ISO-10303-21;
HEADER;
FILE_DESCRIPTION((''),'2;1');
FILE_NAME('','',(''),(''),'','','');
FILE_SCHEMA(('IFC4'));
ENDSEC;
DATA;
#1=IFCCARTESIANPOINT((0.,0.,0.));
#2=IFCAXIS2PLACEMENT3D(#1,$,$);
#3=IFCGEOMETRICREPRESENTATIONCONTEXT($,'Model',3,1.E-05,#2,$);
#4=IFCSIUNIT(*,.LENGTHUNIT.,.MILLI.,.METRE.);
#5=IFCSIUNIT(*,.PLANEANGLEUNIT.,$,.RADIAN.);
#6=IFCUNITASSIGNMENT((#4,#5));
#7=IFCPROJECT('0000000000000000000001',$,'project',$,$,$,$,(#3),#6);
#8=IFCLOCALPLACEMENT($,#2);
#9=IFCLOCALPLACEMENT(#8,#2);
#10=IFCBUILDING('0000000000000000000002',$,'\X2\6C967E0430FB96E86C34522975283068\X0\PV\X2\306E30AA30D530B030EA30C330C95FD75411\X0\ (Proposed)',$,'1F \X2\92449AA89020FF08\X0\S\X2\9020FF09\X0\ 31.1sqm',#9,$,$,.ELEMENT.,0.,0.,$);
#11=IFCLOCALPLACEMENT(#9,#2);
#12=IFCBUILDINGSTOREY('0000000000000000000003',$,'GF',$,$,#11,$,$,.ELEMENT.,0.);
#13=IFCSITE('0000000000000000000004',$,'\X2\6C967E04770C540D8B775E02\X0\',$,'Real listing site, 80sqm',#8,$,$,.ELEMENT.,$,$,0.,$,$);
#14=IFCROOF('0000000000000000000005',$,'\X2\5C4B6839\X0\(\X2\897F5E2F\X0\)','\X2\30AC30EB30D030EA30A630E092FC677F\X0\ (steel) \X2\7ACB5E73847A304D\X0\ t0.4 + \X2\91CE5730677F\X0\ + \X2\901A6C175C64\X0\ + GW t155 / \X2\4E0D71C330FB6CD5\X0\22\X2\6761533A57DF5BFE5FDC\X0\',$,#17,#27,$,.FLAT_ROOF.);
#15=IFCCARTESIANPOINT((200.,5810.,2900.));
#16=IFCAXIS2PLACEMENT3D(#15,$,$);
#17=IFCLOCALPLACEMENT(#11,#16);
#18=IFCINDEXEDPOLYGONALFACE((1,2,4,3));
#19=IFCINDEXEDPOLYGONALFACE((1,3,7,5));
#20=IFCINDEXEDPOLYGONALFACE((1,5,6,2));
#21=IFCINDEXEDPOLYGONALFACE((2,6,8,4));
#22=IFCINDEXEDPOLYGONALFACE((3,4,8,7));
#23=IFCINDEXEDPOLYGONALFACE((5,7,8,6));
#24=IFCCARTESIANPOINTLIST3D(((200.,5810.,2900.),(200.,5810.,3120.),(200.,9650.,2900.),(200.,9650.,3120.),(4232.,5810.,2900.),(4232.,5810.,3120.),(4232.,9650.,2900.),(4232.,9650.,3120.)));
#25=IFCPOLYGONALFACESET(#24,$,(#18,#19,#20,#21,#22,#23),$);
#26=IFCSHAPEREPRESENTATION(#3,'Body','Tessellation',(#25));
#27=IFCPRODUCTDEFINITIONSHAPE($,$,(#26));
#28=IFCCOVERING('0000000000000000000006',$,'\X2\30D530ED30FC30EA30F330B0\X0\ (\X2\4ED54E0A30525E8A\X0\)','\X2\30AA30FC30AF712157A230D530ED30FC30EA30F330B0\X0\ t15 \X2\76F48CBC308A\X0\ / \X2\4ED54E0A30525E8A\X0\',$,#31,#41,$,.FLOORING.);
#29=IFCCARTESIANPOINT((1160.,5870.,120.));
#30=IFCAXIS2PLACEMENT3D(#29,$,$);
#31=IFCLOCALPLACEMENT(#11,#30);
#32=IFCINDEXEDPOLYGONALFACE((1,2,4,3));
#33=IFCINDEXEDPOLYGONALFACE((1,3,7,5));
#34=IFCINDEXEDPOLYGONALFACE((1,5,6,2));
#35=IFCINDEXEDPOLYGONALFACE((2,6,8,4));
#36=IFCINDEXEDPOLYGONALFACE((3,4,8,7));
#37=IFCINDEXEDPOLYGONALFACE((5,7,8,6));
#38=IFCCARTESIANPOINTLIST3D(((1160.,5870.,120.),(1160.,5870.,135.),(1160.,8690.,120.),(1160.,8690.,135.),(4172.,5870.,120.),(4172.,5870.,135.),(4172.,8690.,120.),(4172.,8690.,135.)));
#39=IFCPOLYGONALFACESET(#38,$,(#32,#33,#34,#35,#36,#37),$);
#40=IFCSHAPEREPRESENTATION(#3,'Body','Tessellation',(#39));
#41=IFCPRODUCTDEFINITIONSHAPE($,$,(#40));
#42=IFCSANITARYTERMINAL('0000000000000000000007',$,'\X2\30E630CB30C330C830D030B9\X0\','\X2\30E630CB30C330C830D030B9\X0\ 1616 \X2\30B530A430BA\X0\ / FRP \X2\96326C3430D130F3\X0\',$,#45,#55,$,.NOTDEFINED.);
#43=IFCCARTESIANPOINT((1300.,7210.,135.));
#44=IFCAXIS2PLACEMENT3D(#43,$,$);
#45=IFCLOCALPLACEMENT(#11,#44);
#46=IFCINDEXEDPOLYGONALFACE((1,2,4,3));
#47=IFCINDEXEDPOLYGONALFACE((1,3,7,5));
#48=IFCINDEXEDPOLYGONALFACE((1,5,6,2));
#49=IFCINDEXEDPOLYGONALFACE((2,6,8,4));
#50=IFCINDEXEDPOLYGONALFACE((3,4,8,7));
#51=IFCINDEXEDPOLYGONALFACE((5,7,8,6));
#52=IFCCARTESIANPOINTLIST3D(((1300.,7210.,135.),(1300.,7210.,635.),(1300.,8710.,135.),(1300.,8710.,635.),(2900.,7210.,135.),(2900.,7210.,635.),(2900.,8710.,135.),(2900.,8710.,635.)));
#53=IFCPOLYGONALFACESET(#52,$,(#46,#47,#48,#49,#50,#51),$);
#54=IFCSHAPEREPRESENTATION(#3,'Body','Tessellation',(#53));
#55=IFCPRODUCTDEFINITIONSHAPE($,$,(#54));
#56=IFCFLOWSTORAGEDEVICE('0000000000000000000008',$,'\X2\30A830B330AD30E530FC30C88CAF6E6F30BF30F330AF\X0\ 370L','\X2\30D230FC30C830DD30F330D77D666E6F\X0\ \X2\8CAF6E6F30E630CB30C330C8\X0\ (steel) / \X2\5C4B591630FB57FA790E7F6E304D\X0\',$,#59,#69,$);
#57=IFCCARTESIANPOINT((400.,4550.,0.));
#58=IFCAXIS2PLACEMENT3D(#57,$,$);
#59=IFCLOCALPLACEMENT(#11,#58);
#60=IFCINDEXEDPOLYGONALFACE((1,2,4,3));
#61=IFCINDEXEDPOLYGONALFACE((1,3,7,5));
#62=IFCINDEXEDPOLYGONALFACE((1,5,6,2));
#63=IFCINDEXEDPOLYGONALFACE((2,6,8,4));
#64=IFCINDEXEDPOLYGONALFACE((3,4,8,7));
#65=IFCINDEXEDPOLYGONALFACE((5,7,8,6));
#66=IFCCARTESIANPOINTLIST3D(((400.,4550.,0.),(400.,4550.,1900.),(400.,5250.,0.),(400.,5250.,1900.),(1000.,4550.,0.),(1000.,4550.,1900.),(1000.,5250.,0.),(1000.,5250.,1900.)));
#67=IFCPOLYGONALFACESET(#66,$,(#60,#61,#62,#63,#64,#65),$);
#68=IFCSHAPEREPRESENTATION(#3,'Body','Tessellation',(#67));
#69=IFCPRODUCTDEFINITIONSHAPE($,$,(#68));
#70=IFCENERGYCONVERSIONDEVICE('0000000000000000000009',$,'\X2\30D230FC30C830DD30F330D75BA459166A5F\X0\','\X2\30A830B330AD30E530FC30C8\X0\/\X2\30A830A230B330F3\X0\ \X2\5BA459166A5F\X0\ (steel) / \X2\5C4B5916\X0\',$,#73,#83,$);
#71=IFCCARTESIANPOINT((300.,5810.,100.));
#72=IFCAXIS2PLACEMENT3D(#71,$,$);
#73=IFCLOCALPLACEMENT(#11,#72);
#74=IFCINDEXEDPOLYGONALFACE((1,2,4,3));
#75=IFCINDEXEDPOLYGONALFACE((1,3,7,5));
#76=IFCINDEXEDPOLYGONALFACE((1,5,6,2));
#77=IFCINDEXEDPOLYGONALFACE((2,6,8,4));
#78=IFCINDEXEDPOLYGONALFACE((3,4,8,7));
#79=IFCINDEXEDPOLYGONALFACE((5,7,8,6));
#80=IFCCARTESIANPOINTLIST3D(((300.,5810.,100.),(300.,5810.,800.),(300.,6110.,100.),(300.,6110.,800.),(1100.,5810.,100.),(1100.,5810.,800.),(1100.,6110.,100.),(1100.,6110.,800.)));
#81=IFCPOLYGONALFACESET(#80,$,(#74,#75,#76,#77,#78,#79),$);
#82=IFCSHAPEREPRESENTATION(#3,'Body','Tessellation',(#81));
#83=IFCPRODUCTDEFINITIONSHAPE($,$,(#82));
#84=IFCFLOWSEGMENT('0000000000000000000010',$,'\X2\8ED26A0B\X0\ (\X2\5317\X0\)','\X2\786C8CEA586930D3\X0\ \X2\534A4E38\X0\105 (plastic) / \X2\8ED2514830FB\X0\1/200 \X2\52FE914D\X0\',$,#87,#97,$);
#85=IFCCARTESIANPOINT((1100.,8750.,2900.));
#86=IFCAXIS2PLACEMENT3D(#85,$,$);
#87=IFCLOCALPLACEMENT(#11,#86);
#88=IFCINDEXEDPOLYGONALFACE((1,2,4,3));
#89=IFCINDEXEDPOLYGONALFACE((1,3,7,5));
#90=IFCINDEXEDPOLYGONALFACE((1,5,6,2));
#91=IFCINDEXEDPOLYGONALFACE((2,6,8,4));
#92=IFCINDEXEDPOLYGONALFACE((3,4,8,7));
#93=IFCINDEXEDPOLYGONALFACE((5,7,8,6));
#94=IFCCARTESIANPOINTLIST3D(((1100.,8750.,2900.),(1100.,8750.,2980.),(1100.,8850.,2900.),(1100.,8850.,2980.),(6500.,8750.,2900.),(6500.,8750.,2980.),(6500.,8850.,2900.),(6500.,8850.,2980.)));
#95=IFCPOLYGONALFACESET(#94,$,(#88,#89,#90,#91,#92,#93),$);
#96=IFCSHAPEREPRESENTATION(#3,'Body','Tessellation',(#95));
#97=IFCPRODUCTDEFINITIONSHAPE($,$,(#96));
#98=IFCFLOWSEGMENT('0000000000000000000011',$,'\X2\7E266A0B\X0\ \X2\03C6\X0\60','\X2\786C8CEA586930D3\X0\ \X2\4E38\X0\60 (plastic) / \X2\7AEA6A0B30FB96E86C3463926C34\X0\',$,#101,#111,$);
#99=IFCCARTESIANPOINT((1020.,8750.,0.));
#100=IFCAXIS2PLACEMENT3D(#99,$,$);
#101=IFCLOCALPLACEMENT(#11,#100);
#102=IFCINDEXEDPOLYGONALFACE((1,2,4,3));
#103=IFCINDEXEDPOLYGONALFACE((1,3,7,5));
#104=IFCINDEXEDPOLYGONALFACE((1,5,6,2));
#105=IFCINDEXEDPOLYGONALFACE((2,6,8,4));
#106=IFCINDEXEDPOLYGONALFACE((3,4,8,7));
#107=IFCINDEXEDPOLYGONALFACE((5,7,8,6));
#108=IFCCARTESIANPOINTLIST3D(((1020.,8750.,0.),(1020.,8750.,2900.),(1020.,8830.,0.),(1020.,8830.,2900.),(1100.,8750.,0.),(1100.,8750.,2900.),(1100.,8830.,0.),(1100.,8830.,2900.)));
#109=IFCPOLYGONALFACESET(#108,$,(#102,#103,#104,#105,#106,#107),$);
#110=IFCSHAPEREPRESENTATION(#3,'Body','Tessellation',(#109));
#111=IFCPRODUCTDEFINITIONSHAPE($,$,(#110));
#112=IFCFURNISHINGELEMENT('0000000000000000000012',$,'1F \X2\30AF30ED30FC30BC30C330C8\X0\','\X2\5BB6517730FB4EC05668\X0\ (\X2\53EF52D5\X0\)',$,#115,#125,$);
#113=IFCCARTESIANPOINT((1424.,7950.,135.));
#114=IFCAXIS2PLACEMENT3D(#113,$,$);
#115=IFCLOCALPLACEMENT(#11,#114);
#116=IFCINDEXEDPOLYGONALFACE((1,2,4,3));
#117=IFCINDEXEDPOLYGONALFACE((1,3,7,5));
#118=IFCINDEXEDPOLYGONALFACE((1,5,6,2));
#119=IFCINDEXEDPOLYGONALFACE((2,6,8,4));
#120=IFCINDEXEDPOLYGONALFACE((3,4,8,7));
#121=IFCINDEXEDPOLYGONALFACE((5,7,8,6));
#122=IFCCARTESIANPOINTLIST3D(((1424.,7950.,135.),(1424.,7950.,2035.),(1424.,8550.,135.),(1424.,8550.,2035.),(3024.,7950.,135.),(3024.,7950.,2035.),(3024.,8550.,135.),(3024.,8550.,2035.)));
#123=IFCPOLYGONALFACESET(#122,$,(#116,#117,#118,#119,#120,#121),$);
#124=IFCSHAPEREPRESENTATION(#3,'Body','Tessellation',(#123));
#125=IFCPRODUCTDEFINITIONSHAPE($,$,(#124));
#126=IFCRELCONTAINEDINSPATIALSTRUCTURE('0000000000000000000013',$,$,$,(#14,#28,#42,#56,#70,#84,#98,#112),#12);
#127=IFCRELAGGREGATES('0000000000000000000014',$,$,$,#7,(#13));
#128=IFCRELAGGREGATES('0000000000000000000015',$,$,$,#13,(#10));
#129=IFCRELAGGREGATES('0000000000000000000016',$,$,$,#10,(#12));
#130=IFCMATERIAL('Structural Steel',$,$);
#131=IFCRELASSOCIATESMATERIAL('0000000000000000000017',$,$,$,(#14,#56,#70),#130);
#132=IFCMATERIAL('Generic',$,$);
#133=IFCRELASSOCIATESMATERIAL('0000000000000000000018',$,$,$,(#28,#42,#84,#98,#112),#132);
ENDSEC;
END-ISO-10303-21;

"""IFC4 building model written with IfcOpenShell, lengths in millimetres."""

from ifc_helpers import new_model, si_unit, frame, frame_2d, origin, place, context, project, spatial, rectangle, extrude, material, element, save


model = new_model("IFC4")

# Units and contexts
model_context = context("Model", 3, precision=1e-05, world=origin())
ifc_project = project(units=[si_unit("LENGTHUNIT", "METRE", prefix="MILLI"), si_unit("PLANEANGLEUNIT", "RADIAN")], contexts=[model_context])

# Site, building, storey
site_placement = place(None, origin())
site = spatial("IfcSite", under=ifc_project, at=site_placement, Name="沖縄県名護市", ObjectType="Real listing site, 80sqm", CompositionType="ELEMENT", RefElevation=0.0)
building_placement = place(site_placement, origin())
building = spatial("IfcBuilding", under=site, at=building_placement, Name="沖縄・雨水利用とPVのオフグリッド志向 (Proposed)", ObjectType="1F 鉄骨造（S造） 31.1sqm", CompositionType="ELEMENT", ElevationOfRefHeight=0.0, ElevationOfTerrain=0.0)
storey_placement = place(building_placement, origin())
storey = spatial("IfcBuildingStorey", under=building, at=storey_placement, Name="GF", CompositionType="ELEMENT", Elevation=0.0)

# Roof
ifc_material_1 = material(Name="Structural Steel")
roof_placement = place(storey_placement, frame((200.0, 5810.0, 2900.0)))
element("IfcRoof", 1, at=roof_placement, inside=storey, material=ifc_material_1, Name="屋根(西帯)", Description="ガルバリウム鋼板 (steel) 立平葺き t0.4 + 野地板 + 通気層 + GW t155 / 不燃・法22条区域対応", PredefinedType="FLAT_ROOF", context=model_context, shape_type="SweptSolid", body=[
    extrude(rectangle(XDim=4032.0, YDim=3840.0, at=frame_2d((2016.0, 1920.0))), frame((200.0, 5810.0, 2900.0)), (0.0, 0.0, 1.0), 220.0),
])

# Covering
ifc_material_2 = material(Name="Generic")
covering_placement = place(storey_placement, frame((1160.0, 5870.0, 120.0)))
element("IfcCovering", 2, at=covering_placement, inside=storey, material=ifc_material_2, Name="フローリング (仕上げ床)", Description="オーク無垢フローリング t15 直貼り / 仕上げ床", PredefinedType="FLOORING", context=model_context, shape_type="SweptSolid", body=[
    extrude(rectangle(XDim=3012.0, YDim=2820.0, at=frame_2d((1506.0, 1410.0))), frame((1160.0, 5870.0, 120.0)), (0.0, 0.0, 1.0), 15.0),
])

# Sanitary terminal
sanitary_terminal_placement = place(storey_placement, frame((1300.0, 7210.0, 135.0)))
element("IfcSanitaryTerminal", 3, at=sanitary_terminal_placement, inside=storey, material=ifc_material_2, Name="ユニットバス", Description="ユニットバス 1616 サイズ / FRP 防水パン", PredefinedType="NOTDEFINED", context=model_context, shape_type="SweptSolid", body=[
    extrude(rectangle(XDim=1600.0, YDim=1500.0, at=frame_2d((800.0, 750.0))), frame((1300.0, 7210.0, 135.0)), (0.0, 0.0, 1.0), 500.0),
])

# Flow storage device
flow_storage_device_placement = place(storey_placement, frame((400.0, 4550.0, 0.0)))
element("IfcFlowStorageDevice", 4, at=flow_storage_device_placement, inside=storey, material=ifc_material_1, Name="エコキュート貯湯タンク 370L", Description="ヒートポンプ給湯 貯湯ユニット (steel) / 屋外・基礎置き", context=model_context, shape_type="SweptSolid", body=[
    extrude(rectangle(XDim=600.0, YDim=700.0, at=frame_2d((300.0, 350.0))), frame((400.0, 4550.0, 0.0)), (0.0, 0.0, 1.0), 1900.0),
])

# Energy conversion device
energy_conversion_device_placement = place(storey_placement, frame((300.0, 5810.0, 100.0)))
element("IfcEnergyConversionDevice", 5, at=energy_conversion_device_placement, inside=storey, material=ifc_material_1, Name="ヒートポンプ室外機", Description="エコキュート/エアコン 室外機 (steel) / 屋外", context=model_context, shape_type="SweptSolid", body=[
    extrude(rectangle(XDim=800.0, YDim=300.0, at=frame_2d((400.0, 150.0))), frame((300.0, 5810.0, 100.0)), (0.0, 0.0, 1.0), 700.0),
])

# Flow segments
flow_segment_1_placement = place(storey_placement, frame((1100.0, 8750.0, 2900.0)))
element("IfcFlowSegment", 6, at=flow_segment_1_placement, inside=storey, material=ifc_material_2, Name="軒樋 (北)", Description="硬質塩ビ 半丸105 (plastic) / 軒先・1/200 勾配", context=model_context, shape_type="SweptSolid", body=[
    extrude(rectangle(XDim=5400.0, YDim=100.0, at=frame_2d((2700.0, 50.0))), frame((1100.0, 8750.0, 2900.0)), (0.0, 0.0, 1.0), 80.0),
])
flow_segment_2_placement = place(storey_placement, frame((1020.0, 8750.0, 0.0)))
element("IfcFlowSegment", 7, at=flow_segment_2_placement, inside=storey, material=ifc_material_2, Name="縦樋 φ60", Description="硬質塩ビ 丸60 (plastic) / 竪樋・雨水排水", context=model_context, shape_type="SweptSolid", body=[
    extrude(rectangle(XDim=80.0, YDim=80.0, at=frame_2d((40.0, 40.0))), frame((1020.0, 8750.0, 0.0)), (0.0, 0.0, 1.0), 2900.0),
])

# Furnishing element
furnishing_placement = place(storey_placement, frame((1424.0, 7950.0, 135.0)))
element("IfcFurnishingElement", 8, at=furnishing_placement, inside=storey, material=ifc_material_2, Name="1F クローゼット", Description="家具・什器 (可動)", context=model_context, shape_type="SweptSolid", body=[
    extrude(rectangle(XDim=1600.0, YDim=600.0, at=frame_2d((800.0, 300.0))), frame((1424.0, 7950.0, 135.0)), (0.0, 0.0, 1.0), 1900.0),
])

save(model, "model.ifc")
